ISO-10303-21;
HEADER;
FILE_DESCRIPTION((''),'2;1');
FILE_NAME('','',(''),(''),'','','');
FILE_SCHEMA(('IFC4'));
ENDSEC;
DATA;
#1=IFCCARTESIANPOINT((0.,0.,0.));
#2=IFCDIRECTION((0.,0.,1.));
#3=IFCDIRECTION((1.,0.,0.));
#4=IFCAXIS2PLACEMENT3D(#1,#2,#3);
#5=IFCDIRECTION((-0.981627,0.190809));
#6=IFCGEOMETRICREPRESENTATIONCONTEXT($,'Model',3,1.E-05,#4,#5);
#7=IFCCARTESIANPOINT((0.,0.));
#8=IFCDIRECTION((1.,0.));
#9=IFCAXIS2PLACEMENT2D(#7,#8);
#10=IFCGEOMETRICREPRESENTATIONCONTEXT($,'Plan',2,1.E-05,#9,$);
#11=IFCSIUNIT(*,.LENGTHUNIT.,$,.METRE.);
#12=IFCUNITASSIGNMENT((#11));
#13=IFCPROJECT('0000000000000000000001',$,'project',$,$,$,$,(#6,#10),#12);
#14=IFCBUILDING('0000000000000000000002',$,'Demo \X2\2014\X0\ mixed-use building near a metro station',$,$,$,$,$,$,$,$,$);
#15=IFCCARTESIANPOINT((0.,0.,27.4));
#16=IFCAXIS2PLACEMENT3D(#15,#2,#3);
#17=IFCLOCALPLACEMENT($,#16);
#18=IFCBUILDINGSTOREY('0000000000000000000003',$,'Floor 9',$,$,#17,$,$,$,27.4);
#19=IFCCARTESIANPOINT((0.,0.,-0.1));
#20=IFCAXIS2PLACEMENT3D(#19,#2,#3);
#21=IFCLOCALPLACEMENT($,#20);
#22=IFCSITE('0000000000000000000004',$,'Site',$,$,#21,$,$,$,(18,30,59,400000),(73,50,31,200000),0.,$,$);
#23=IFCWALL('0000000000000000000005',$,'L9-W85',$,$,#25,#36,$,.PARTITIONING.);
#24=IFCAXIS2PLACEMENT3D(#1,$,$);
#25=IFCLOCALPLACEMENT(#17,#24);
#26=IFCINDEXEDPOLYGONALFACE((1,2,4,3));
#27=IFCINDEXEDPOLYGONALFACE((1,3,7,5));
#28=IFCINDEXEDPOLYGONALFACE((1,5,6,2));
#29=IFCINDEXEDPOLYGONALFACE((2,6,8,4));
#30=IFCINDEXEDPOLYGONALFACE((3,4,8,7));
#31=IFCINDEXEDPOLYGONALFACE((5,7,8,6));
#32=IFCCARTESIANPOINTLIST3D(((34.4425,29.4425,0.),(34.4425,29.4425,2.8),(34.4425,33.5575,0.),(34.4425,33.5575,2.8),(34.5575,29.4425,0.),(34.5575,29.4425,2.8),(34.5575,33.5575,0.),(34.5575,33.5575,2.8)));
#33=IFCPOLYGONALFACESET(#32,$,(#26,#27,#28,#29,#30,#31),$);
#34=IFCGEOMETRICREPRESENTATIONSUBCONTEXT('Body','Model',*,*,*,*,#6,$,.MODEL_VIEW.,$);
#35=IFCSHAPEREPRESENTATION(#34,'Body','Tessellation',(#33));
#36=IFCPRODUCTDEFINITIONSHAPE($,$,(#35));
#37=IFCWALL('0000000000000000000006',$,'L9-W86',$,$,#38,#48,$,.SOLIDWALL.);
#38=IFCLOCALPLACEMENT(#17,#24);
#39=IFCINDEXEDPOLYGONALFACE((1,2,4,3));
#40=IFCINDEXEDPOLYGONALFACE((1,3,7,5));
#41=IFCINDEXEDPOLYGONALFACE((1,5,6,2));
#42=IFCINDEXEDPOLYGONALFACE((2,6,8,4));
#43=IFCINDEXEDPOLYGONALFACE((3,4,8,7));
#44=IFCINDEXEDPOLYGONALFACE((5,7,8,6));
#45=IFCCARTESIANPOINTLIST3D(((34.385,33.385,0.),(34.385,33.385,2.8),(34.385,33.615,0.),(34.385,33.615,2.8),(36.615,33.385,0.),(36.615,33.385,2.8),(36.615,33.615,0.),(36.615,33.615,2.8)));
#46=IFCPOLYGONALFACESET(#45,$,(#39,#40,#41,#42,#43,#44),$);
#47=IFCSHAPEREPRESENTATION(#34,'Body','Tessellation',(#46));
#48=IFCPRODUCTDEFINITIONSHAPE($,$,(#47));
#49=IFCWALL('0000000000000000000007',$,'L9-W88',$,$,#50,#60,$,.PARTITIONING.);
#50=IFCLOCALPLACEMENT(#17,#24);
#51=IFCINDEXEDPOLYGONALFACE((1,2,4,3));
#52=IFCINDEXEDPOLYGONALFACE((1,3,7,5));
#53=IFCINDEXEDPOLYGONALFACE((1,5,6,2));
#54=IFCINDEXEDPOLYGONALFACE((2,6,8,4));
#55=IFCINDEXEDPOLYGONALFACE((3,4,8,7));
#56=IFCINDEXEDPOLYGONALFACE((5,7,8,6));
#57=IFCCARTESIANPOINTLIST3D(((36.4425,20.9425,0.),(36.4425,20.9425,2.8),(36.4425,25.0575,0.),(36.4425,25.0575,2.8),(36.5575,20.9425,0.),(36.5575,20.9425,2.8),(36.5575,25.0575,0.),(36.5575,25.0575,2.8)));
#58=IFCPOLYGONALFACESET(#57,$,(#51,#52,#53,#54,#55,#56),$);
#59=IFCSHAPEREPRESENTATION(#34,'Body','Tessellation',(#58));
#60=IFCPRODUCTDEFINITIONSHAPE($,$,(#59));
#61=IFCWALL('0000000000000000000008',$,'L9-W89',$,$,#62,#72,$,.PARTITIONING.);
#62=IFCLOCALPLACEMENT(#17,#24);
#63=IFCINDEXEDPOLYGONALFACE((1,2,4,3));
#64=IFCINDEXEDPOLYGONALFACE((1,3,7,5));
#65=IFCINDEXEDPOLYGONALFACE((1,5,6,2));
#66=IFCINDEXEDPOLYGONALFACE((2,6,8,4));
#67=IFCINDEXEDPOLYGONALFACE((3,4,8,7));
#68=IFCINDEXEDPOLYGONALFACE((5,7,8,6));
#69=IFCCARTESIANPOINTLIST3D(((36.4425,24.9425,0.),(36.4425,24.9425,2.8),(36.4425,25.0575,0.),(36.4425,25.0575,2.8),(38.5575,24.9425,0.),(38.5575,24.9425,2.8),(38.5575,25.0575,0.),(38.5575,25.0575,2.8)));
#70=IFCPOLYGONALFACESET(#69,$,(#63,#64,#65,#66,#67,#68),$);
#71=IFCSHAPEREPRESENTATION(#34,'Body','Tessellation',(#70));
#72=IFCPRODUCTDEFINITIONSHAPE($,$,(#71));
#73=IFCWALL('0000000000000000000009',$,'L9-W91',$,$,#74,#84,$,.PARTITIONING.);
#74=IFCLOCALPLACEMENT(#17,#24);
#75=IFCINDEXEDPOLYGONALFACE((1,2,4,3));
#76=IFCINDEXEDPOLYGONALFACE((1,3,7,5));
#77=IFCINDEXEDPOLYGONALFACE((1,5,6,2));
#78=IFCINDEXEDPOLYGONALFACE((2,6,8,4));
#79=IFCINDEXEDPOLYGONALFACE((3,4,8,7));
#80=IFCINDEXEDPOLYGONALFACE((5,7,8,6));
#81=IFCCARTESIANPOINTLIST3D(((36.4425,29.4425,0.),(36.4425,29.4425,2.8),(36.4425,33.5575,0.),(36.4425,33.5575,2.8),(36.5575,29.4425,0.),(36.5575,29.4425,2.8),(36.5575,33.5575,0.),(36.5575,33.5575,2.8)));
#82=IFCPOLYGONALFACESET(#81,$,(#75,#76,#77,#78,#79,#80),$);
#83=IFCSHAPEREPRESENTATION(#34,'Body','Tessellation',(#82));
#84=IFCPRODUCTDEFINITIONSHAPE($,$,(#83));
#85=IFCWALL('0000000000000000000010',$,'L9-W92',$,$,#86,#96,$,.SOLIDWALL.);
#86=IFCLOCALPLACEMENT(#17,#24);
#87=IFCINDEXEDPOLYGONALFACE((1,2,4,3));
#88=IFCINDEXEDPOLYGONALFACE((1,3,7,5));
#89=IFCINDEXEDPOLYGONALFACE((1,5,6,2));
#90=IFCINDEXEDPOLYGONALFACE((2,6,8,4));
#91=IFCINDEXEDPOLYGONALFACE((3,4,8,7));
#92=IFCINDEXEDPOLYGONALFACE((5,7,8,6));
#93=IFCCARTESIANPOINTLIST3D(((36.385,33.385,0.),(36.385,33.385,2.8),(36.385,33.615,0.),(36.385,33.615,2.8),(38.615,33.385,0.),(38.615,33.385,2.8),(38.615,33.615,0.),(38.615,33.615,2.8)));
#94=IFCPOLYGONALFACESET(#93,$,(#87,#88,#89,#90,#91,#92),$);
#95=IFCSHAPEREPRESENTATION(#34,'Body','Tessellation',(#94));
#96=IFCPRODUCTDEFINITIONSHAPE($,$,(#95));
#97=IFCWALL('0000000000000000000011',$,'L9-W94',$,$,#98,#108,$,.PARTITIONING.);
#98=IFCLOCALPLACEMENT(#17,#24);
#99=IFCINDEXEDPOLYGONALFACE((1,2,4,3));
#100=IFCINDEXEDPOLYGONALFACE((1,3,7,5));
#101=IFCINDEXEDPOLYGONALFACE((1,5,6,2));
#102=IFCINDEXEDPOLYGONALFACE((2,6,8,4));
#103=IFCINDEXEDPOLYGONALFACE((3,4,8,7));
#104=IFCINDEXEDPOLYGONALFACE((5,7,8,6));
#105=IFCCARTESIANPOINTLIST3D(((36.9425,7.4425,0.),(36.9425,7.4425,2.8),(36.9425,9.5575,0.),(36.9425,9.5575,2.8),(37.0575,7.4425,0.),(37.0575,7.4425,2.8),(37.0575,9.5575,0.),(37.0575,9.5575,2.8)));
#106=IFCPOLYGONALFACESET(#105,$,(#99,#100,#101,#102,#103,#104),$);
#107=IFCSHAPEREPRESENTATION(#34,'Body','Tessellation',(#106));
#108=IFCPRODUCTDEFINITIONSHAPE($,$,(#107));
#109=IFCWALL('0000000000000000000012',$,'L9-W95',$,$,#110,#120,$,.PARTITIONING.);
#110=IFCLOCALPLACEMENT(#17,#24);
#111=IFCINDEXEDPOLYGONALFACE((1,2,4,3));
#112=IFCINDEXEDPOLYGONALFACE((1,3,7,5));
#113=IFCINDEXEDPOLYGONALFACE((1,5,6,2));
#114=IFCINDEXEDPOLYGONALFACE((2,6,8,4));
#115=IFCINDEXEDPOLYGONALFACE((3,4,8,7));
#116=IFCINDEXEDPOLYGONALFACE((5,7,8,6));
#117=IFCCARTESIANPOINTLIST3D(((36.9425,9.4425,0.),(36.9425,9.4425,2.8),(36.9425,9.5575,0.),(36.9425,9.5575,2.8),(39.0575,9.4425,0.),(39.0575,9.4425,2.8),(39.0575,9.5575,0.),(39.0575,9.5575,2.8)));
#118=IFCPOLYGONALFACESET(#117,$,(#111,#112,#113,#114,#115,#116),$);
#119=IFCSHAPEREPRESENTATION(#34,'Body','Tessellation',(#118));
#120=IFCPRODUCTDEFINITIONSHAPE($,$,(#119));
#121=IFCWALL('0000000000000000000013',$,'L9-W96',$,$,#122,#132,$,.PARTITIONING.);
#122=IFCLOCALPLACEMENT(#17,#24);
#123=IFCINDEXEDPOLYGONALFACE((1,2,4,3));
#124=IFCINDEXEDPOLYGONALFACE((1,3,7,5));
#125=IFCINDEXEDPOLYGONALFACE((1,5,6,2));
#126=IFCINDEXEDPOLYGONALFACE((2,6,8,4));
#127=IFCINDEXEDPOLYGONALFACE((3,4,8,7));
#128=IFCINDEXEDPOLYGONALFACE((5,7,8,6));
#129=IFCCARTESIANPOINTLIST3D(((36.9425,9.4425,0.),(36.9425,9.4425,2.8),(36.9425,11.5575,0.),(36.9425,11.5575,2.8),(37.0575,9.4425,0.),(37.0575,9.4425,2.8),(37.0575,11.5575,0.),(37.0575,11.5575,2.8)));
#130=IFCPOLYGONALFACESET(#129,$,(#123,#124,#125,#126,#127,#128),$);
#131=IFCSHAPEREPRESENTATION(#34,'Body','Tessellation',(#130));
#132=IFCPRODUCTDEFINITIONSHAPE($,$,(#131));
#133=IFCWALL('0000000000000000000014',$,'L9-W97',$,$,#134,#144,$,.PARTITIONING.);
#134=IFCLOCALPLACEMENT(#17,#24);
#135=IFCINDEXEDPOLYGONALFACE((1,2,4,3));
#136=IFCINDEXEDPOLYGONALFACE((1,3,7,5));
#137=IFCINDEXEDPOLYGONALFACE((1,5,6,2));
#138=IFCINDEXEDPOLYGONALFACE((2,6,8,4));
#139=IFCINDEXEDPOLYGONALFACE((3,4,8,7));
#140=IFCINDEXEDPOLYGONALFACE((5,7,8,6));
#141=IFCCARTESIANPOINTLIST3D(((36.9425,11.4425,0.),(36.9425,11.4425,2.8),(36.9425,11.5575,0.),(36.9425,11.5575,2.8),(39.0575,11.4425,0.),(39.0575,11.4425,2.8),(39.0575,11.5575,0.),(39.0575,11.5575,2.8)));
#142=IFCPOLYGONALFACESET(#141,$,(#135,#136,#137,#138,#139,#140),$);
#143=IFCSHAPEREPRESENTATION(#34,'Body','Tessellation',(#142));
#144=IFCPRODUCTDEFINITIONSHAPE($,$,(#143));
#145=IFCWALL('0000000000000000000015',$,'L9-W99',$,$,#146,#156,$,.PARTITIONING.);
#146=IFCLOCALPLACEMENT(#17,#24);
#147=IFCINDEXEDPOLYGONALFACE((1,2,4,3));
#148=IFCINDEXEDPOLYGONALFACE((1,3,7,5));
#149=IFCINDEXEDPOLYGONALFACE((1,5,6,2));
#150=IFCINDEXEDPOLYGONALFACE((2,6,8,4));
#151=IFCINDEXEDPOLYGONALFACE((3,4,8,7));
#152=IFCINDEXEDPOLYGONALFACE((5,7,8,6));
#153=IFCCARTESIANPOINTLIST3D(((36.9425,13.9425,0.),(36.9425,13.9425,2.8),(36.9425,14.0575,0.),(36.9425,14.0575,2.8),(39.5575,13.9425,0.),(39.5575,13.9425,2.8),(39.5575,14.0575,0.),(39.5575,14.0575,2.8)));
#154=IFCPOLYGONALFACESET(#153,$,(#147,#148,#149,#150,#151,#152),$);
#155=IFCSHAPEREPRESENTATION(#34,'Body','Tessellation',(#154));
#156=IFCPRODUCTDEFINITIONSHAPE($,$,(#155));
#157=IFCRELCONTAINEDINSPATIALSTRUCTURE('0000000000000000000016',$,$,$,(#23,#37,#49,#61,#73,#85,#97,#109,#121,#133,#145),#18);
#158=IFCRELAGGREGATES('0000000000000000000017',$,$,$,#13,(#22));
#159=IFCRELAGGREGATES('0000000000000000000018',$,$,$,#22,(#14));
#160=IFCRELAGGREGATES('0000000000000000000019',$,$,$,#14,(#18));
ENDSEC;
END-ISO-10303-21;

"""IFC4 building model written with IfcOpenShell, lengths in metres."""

from ifc_helpers import new_model, si_unit, direction, frame, origin_with_axes, origin_2d_with_axis, place, context, subcontext, project, spatial, line, indexed_curve, outline, extrude, element, save


model = new_model("IFC4")

# Units and contexts
model_context = context("Model", 3, precision=1e-05, world=origin_with_axes(), true_north=direction((-0.981627, 0.190809)))
plan_context = context("Plan", 2, precision=1e-05, world=origin_2d_with_axis())
body_context = subcontext(model_context, "Body", "Model", "MODEL_VIEW")
ifc_project = project(units=[si_unit("LENGTHUNIT", "METRE")], contexts=[model_context, plan_context])

# Site, building, storey
site_placement = place(None, frame((0.0, 0.0, -0.1), z_axis=(0.0, 0.0, 1.0), x_axis=(1.0, 0.0, 0.0)))
site = spatial("IfcSite", under=ifc_project, at=site_placement, Name="Site", RefLatitude=(18, 30, 59, 400000), RefLongitude=(73, 50, 31, 200000), RefElevation=0.0)
building = spatial("IfcBuilding", under=site, Name="Demo — mixed-use building near a metro station")
storey_placement = place(None, frame((0.0, 0.0, 27.4), z_axis=(0.0, 0.0, 1.0), x_axis=(1.0, 0.0, 0.0)))
storey = spatial("IfcBuildingStorey", under=building, at=storey_placement, Name="Floor 9", Elevation=27.4)

# Walls
wall_1_placement = place(storey_placement, frame((0.0, 0.0, -27.4), z_axis=(0.0, 0.0, 1.0), x_axis=(1.0, 0.0, 0.0)))
element("IfcWall", 1, at=wall_1_placement, inside=storey, Name="L9-W85", PredefinedType="PARTITIONING", context=body_context, shape_type="SweptSolid", body=[
    extrude(outline(indexed_curve([(34.4425, 29.4425), (34.4425, 33.5575), (34.5575, 33.5575), (34.5575, 29.4425)], segments=[line(1, 2, 3, 4, 1)])), frame((0.0, 0.0, 27.4), z_axis=(0.0, 0.0, 1.0), x_axis=(1.0, 0.0, 0.0)), (0.0, 0.0, 1.0), 2.8),
])
wall_2_placement = place(storey_placement, frame((0.0, 0.0, -27.4), z_axis=(0.0, 0.0, 1.0), x_axis=(1.0, 0.0, 0.0)))
element("IfcWall", 2, at=wall_2_placement, inside=storey, Name="L9-W86", PredefinedType="SOLIDWALL", context=body_context, shape_type="SweptSolid", body=[
    extrude(outline(indexed_curve([(36.615, 33.385), (34.385, 33.385), (34.385, 33.615), (36.615, 33.615)], segments=[line(1, 2, 3, 4, 1)])), frame((0.0, 0.0, 27.4), z_axis=(0.0, 0.0, 1.0), x_axis=(1.0, 0.0, 0.0)), (0.0, 0.0, 1.0), 2.8),
])

# Walls
wall_3_placement = place(storey_placement, frame((0.0, 0.0, -27.4), z_axis=(0.0, 0.0, 1.0), x_axis=(1.0, 0.0, 0.0)))
element("IfcWall", 3, at=wall_3_placement, inside=storey, Name="L9-W88", PredefinedType="PARTITIONING", context=body_context, shape_type="SweptSolid", body=[
    extrude(outline(indexed_curve([(36.5575, 25.0575), (36.5575, 20.9425), (36.4425, 20.9425), (36.4425, 25.0575)], segments=[line(1, 2, 3, 4, 1)])), frame((0.0, 0.0, 27.4), z_axis=(0.0, 0.0, 1.0), x_axis=(1.0, 0.0, 0.0)), (0.0, 0.0, 1.0), 2.8),
])
wall_4_placement = place(storey_placement, frame((0.0, 0.0, -27.4), z_axis=(0.0, 0.0, 1.0), x_axis=(1.0, 0.0, 0.0)))
element("IfcWall", 4, at=wall_4_placement, inside=storey, Name="L9-W89", PredefinedType="PARTITIONING", context=body_context, shape_type="SweptSolid", body=[
    extrude(outline(indexed_curve([(38.5575, 24.9425), (36.4425, 24.9425), (36.4425, 25.0575), (38.5575, 25.0575)], segments=[line(1, 2, 3, 4, 1)])), frame((0.0, 0.0, 27.4), z_axis=(0.0, 0.0, 1.0), x_axis=(1.0, 0.0, 0.0)), (0.0, 0.0, 1.0), 2.8),
])

# Walls
wall_5_placement = place(storey_placement, frame((0.0, 0.0, -27.4), z_axis=(0.0, 0.0, 1.0), x_axis=(1.0, 0.0, 0.0)))
element("IfcWall", 5, at=wall_5_placement, inside=storey, Name="L9-W91", PredefinedType="PARTITIONING", context=body_context, shape_type="SweptSolid", body=[
    extrude(outline(indexed_curve([(36.5575, 33.5575), (36.5575, 29.4425), (36.4425, 29.4425), (36.4425, 33.5575)], segments=[line(1, 2, 3, 4, 1)])), frame((0.0, 0.0, 27.4), z_axis=(0.0, 0.0, 1.0), x_axis=(1.0, 0.0, 0.0)), (0.0, 0.0, 1.0), 2.8),
])
wall_6_placement = place(storey_placement, frame((0.0, 0.0, -27.4), z_axis=(0.0, 0.0, 1.0), x_axis=(1.0, 0.0, 0.0)))
element("IfcWall", 6, at=wall_6_placement, inside=storey, Name="L9-W92", PredefinedType="SOLIDWALL", context=body_context, shape_type="SweptSolid", body=[
    extrude(outline(indexed_curve([(38.615, 33.385), (36.385, 33.385), (36.385, 33.615), (38.615, 33.615)], segments=[line(1, 2, 3, 4, 1)])), frame((0.0, 0.0, 27.4), z_axis=(0.0, 0.0, 1.0), x_axis=(1.0, 0.0, 0.0)), (0.0, 0.0, 1.0), 2.8),
])

# Walls
wall_7_placement = place(storey_placement, frame((0.0, 0.0, -27.4), z_axis=(0.0, 0.0, 1.0), x_axis=(1.0, 0.0, 0.0)))
element("IfcWall", 7, at=wall_7_placement, inside=storey, Name="L9-W94", PredefinedType="PARTITIONING", context=body_context, shape_type="SweptSolid", body=[
    extrude(outline(indexed_curve([(37.0575, 9.5575), (37.0575, 7.4425), (36.9425, 7.4425), (36.9425, 9.5575)], segments=[line(1, 2, 3, 4, 1)])), frame((0.0, 0.0, 27.4), z_axis=(0.0, 0.0, 1.0), x_axis=(1.0, 0.0, 0.0)), (0.0, 0.0, 1.0), 2.8),
])
wall_8_placement = place(storey_placement, frame((0.0, 0.0, -27.4), z_axis=(0.0, 0.0, 1.0), x_axis=(1.0, 0.0, 0.0)))
element("IfcWall", 8, at=wall_8_placement, inside=storey, Name="L9-W95", PredefinedType="PARTITIONING", context=body_context, shape_type="SweptSolid", body=[
    extrude(outline(indexed_curve([(39.0575, 9.4425), (36.9425, 9.4425), (36.9425, 9.5575), (39.0575, 9.5575)], segments=[line(1, 2, 3, 4, 1)])), frame((0.0, 0.0, 27.4), z_axis=(0.0, 0.0, 1.0), x_axis=(1.0, 0.0, 0.0)), (0.0, 0.0, 1.0), 2.8),
])
wall_9_placement = place(storey_placement, frame((0.0, 0.0, -27.4), z_axis=(0.0, 0.0, 1.0), x_axis=(1.0, 0.0, 0.0)))
element("IfcWall", 9, at=wall_9_placement, inside=storey, Name="L9-W96", PredefinedType="PARTITIONING", context=body_context, shape_type="SweptSolid", body=[
    extrude(outline(indexed_curve([(37.0575, 11.5575), (37.0575, 9.4425), (36.9425, 9.4425), (36.9425, 11.5575)], segments=[line(1, 2, 3, 4, 1)])), frame((0.0, 0.0, 27.4), z_axis=(0.0, 0.0, 1.0), x_axis=(1.0, 0.0, 0.0)), (0.0, 0.0, 1.0), 2.8),
])
wall_10_placement = place(storey_placement, frame((0.0, 0.0, -27.4), z_axis=(0.0, 0.0, 1.0), x_axis=(1.0, 0.0, 0.0)))
element("IfcWall", 10, at=wall_10_placement, inside=storey, Name="L9-W97", PredefinedType="PARTITIONING", context=body_context, shape_type="SweptSolid", body=[
    extrude(outline(indexed_curve([(36.9425, 11.5575), (39.0575, 11.5575), (39.0575, 11.4425), (36.9425, 11.4425)], segments=[line(1, 2, 3, 4, 1)])), frame((0.0, 0.0, 27.4), z_axis=(0.0, 0.0, 1.0), x_axis=(1.0, 0.0, 0.0)), (0.0, 0.0, 1.0), 2.8),
])

# Wall
wall_11_placement = place(storey_placement, frame((0.0, 0.0, -27.4), z_axis=(0.0, 0.0, 1.0), x_axis=(1.0, 0.0, 0.0)))
element("IfcWall", 11, at=wall_11_placement, inside=storey, Name="L9-W99", PredefinedType="PARTITIONING", context=body_context, shape_type="SweptSolid", body=[
    extrude(outline(indexed_curve([(39.5575, 13.9425), (36.9425, 13.9425), (36.9425, 14.0575), (39.5575, 14.0575)], segments=[line(1, 2, 3, 4, 1)])), frame((0.0, 0.0, 27.4), z_axis=(0.0, 0.0, 1.0), x_axis=(1.0, 0.0, 0.0)), (0.0, 0.0, 1.0), 2.8),
])

save(model, "model.ifc")
